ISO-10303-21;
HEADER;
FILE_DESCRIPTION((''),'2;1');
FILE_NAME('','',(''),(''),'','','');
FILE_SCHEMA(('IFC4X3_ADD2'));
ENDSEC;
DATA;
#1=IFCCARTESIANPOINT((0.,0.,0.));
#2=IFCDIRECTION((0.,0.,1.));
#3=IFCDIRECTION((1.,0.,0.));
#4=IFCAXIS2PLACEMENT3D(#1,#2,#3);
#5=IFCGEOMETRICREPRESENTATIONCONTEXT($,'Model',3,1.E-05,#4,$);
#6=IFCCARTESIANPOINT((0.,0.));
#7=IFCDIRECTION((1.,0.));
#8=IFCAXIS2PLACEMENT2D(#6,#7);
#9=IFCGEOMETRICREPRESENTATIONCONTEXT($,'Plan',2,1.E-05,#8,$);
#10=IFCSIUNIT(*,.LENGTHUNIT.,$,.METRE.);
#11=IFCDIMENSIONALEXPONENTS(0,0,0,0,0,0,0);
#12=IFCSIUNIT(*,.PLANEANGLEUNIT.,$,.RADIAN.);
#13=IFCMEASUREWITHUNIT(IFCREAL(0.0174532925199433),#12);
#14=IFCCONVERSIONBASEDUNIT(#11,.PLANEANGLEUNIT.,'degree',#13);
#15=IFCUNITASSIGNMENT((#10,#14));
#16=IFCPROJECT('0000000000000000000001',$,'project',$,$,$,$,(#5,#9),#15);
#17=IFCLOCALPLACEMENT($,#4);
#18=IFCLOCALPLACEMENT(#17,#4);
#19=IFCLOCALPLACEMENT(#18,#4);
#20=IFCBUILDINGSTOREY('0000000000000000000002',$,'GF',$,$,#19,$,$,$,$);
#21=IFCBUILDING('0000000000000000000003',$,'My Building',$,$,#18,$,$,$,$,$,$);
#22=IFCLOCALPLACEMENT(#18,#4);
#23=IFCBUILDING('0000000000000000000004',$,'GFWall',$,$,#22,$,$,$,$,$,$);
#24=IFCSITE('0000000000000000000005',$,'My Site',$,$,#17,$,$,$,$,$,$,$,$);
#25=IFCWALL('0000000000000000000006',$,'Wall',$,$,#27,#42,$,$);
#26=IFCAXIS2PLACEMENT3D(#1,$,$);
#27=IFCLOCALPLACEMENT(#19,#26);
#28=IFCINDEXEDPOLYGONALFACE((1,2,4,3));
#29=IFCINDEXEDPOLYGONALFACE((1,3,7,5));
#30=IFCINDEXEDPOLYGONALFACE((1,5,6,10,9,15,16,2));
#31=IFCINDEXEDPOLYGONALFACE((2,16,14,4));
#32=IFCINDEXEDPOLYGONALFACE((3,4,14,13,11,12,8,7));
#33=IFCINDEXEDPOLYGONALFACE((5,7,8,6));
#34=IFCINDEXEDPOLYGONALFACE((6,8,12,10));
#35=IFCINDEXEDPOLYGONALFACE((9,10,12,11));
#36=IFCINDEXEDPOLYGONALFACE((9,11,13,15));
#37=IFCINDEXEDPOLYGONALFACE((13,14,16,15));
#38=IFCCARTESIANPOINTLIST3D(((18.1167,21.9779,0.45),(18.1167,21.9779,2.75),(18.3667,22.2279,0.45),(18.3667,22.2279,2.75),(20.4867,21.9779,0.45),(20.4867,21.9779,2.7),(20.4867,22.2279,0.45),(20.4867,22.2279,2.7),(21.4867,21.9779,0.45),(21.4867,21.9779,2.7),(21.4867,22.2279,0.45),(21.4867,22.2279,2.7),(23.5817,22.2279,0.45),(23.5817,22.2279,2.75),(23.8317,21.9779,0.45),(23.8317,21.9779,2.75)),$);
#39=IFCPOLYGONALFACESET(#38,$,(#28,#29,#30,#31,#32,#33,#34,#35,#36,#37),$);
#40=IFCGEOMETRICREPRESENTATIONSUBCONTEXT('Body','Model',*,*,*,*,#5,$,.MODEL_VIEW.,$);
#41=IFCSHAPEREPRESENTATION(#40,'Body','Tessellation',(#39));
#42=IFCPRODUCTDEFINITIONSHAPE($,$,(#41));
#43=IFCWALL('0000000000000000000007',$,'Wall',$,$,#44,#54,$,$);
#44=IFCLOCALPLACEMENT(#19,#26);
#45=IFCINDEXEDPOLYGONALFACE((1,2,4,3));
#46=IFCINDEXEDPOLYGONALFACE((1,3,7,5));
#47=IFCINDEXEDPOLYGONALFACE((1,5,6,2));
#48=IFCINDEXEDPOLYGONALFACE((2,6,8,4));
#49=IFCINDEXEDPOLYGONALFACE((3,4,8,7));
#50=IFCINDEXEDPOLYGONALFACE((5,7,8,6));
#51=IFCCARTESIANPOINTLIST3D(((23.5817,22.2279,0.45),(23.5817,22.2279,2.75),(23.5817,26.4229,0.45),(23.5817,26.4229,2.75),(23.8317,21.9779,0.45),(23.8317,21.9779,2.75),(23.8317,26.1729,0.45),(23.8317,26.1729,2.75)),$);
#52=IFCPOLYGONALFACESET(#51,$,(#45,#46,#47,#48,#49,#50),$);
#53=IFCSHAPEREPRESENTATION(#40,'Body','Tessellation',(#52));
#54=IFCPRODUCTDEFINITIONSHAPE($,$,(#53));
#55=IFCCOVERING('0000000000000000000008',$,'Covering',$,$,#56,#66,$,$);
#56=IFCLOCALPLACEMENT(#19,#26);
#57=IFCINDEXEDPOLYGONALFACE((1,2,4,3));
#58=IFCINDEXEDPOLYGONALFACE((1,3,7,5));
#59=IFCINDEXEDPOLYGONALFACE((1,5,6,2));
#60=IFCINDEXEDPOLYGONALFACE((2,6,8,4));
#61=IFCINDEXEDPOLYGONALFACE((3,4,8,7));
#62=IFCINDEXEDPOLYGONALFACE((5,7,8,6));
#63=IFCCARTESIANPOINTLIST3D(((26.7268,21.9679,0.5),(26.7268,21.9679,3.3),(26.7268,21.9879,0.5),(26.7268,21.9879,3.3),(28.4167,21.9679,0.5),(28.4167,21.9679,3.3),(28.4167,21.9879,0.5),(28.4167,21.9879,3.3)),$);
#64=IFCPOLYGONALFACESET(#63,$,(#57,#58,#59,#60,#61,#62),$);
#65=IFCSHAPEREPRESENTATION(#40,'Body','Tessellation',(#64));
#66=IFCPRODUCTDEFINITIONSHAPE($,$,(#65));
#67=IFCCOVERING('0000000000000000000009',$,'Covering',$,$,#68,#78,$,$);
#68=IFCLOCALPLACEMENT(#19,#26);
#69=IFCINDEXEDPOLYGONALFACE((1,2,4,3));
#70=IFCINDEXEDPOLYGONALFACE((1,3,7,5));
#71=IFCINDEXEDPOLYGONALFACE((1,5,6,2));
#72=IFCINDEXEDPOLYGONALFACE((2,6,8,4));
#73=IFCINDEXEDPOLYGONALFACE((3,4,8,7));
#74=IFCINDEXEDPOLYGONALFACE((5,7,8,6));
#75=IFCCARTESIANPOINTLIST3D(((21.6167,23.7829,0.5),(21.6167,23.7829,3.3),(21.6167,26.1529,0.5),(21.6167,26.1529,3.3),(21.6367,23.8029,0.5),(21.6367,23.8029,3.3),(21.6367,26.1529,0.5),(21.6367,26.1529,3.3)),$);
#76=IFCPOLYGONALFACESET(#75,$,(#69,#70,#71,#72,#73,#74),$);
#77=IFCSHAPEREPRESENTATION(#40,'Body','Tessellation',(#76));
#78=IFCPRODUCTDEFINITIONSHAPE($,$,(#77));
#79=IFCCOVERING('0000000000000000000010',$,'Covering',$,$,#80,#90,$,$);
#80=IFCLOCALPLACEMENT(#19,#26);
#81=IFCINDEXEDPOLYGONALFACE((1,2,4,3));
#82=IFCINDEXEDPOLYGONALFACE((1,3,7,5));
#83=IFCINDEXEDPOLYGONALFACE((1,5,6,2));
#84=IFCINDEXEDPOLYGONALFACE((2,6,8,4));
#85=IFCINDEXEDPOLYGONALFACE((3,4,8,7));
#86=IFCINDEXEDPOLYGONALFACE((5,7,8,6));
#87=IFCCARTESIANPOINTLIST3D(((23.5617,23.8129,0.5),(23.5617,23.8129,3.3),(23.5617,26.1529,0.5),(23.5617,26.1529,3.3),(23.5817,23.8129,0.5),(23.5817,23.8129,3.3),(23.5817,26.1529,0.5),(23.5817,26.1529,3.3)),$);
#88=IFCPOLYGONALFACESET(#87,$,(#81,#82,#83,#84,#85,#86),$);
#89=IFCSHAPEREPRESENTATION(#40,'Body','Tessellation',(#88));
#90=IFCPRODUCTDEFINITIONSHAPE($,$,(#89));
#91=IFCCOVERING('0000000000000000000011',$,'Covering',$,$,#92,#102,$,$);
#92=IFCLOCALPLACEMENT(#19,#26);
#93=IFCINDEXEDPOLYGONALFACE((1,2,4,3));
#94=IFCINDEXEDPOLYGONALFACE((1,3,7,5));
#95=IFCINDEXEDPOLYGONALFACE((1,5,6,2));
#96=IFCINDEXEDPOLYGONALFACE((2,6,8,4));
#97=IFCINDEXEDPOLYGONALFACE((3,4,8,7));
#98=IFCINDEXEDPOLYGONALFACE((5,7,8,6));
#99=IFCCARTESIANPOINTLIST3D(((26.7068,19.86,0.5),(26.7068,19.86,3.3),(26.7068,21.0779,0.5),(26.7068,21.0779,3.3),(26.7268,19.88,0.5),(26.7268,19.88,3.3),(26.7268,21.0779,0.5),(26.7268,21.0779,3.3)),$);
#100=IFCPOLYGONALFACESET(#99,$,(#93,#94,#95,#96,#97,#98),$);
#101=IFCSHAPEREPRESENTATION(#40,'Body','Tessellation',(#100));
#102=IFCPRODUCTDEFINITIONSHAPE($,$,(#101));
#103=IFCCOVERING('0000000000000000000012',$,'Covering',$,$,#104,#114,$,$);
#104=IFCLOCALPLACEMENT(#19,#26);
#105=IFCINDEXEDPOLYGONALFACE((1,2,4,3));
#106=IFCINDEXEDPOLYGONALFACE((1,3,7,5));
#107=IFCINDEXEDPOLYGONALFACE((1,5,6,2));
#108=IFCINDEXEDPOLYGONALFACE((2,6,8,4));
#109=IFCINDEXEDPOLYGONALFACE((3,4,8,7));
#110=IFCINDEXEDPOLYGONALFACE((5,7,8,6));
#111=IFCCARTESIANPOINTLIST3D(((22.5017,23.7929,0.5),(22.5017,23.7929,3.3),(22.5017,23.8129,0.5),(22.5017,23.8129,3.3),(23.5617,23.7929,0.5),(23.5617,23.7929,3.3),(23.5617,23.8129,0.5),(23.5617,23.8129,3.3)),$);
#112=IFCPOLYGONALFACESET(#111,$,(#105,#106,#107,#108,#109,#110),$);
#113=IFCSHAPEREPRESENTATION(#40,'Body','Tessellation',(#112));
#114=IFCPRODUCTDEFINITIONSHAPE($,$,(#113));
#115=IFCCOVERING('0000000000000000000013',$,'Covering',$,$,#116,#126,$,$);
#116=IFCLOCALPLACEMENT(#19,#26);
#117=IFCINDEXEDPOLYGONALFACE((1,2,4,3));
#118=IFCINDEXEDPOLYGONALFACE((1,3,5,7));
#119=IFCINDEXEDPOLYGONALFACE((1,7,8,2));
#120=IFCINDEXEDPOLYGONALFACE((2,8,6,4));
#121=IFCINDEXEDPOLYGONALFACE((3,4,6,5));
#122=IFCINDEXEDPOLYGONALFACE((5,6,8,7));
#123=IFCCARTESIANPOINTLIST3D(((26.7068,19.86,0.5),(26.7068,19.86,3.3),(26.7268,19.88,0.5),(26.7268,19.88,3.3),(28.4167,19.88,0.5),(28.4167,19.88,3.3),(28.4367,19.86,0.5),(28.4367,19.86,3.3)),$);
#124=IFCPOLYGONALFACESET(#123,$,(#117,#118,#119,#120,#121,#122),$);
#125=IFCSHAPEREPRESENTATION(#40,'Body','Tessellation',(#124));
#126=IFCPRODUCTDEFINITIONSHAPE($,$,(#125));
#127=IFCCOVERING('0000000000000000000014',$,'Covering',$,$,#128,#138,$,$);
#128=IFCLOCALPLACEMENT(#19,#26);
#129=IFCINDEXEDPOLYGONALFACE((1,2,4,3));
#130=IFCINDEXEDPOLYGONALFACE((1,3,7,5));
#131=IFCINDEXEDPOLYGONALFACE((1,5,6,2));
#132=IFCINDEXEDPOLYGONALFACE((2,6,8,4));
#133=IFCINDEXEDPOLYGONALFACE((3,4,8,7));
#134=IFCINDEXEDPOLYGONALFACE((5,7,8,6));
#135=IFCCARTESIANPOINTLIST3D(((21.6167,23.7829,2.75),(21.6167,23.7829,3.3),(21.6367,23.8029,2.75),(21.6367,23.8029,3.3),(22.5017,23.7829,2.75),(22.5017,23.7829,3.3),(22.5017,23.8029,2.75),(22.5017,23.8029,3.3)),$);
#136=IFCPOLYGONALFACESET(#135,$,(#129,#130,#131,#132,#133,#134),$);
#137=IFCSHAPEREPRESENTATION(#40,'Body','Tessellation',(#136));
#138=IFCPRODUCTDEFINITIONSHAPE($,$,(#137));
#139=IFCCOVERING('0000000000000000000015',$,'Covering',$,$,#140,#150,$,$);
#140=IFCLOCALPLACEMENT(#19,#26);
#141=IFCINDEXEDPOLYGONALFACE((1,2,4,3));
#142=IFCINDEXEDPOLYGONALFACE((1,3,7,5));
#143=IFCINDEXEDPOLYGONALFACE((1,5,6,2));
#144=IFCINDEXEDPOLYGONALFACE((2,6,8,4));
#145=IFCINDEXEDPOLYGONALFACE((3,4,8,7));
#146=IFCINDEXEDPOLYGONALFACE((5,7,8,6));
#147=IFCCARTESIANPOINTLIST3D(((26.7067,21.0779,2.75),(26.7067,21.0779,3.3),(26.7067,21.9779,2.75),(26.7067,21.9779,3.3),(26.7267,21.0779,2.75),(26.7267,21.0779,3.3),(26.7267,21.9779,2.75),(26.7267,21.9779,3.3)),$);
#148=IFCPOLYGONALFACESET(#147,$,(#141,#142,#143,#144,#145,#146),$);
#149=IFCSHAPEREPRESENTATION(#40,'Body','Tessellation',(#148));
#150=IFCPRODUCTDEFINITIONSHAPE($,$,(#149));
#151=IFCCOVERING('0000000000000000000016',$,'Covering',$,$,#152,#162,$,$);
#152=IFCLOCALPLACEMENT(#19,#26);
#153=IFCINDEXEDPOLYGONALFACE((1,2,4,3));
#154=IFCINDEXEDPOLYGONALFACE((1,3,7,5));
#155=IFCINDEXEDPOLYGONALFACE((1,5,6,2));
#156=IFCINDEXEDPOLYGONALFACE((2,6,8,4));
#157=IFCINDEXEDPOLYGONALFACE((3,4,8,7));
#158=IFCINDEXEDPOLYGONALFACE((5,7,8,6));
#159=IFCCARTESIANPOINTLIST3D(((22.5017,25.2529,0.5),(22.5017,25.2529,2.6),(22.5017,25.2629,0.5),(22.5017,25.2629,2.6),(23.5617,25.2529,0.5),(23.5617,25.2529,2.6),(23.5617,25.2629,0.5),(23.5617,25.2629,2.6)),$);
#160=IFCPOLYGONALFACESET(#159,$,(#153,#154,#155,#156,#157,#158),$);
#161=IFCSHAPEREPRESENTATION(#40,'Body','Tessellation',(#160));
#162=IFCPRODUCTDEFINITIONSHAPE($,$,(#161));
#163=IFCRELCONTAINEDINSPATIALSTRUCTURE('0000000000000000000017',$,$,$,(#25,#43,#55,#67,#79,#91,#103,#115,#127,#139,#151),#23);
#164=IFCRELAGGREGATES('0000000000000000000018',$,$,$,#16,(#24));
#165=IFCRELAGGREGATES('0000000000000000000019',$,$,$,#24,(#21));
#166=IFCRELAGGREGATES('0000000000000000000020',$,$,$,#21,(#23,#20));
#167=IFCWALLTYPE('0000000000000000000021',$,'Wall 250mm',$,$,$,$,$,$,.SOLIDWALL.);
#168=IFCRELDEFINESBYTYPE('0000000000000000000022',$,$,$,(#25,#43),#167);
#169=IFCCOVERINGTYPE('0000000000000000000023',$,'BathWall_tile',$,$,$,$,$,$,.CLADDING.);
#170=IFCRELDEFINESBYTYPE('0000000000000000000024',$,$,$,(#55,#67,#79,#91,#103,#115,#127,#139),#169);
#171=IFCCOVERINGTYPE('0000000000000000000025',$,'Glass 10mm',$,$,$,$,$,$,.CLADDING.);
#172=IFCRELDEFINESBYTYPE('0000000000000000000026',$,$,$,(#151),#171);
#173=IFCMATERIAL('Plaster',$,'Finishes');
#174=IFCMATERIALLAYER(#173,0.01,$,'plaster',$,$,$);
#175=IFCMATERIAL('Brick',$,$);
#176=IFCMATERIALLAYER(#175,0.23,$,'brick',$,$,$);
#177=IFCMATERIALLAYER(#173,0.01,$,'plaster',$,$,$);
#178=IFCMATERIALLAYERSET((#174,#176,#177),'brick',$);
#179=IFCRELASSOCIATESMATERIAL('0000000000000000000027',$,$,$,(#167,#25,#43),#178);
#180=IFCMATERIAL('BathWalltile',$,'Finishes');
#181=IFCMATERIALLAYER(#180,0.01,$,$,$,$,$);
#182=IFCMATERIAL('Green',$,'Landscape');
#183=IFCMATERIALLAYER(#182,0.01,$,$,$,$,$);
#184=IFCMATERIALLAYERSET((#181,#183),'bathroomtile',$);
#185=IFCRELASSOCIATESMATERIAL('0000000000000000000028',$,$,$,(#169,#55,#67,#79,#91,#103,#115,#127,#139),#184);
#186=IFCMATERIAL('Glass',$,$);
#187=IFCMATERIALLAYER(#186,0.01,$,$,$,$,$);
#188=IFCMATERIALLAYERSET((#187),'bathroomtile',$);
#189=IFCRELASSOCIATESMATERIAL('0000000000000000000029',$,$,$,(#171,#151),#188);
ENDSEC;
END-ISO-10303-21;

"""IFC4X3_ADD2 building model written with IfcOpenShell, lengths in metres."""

from ifc_helpers import new_model, entity, si_unit, converted_unit, frame, origin_with_axes, origin_2d_with_axis, place, context, subcontext, project, spatial, line, indexed_curve, outline, extrude, source, transform, mapped, material, layer, layer_set, layer_usage, type_object, element, save


model = new_model("IFC4X3_ADD2")

# Units and contexts
model_context = context("Model", 3, precision=1e-05, world=origin_with_axes())
plan_context = context("Plan", 2, precision=1e-05, world=origin_2d_with_axis())
body_context_1 = subcontext(model_context, "Body", "Model", "MODEL_VIEW")
ifc_project = project(units=[si_unit("LENGTHUNIT", "METRE"), converted_unit("PLANEANGLEUNIT", "degree", entity("IfcReal", 0.0174532925199433), si_unit("PLANEANGLEUNIT", "RADIAN"), dimensions=[0, 0, 0, 0, 0, 0, 0])], contexts=[model_context, plan_context])

# Site, buildings
site_placement = place(None, origin_with_axes())
site = spatial("IfcSite", under=ifc_project, at=site_placement, Name="My Site")
building_1_placement = place(site_placement, origin_with_axes())
building_1 = spatial("IfcBuilding", under=site, at=building_1_placement, Name="My Building")
building_2_placement = place(building_1_placement, origin_with_axes())
building_2 = spatial("IfcBuilding", under=building_1, at=building_2_placement, Name="GFWall")

# Shared definitions
ifc_material_1 = material(Name="Plaster", Category="Finishes")
ifc_material_2 = material(Name="Brick")

# Shared definitions
ifc_layer_1 = layer(ifc_material_1, 0.01, Name="plaster")
ifc_layer_2 = layer(ifc_material_2, 0.23, Name="brick")
ifc_layer_3 = layer(ifc_material_1, 0.01, Name="plaster")
ifc_layer_set_1 = layer_set([ifc_layer_1, ifc_layer_2, ifc_layer_3], Name="brick")
wall_type_1 = type_object("IfcWallType", Name="Wall 250mm", PredefinedType="SOLIDWALL", material=ifc_layer_set_1)

# Shared definitions
storey_placement = place(building_1_placement, origin_with_axes())
storey = spatial("IfcBuildingStorey", under=building_1, at=storey_placement, Name="GF")

# Wall, opening
ifc_layer_usage_1 = layer_usage(ifc_layer_set_1, "AXIS2", "POSITIVE", 0.0)
wall_1_placement = place(building_2_placement, frame((18.3667, 21.9779, 0.45), z_axis=(0.0, 0.0, 1.0), x_axis=(1.0, 0.0, 0.0)))
wall_1 = element("IfcWall", 1, at=wall_1_placement, inside=building_2, type_object=wall_type_1, material=ifc_layer_usage_1, Name="Wall", context=body_context_1, shape_type="SweptSolid", body=[
    extrude(outline(indexed_curve([(-0.25, 0.0), (0.0, 0.25), (5.215, 0.25), (5.465, 0.0)], segments=[line(1, 2, 3, 4, 1)])), origin_with_axes(), (0.0, 0.0, 1.0), 2.3),
])
shared_shape_1 = source(origin_with_axes(), body_context_1, "Body", "SweptSolid", [
    extrude(outline(indexed_curve([(0.0, 0.0), (1.0, 0.0), (1.0, 2.25), (0.0, 2.25), (0.0, 0.0)])), frame((0.0, -0.6, 0.0), z_axis=(0.0, -1.0, 0.0), x_axis=(1.0, 0.0, 0.0)), (0.0, 0.0, -1.0), 1.2),
])
opening_1_placement = place(wall_1_placement, frame((2.12, 0.0, 0.0), z_axis=(0.0, 0.0, 1.0), x_axis=(1.0, 0.0, 0.0)))
element("IfcOpeningElement", 2, at=opening_1_placement, cuts=wall_1, PredefinedType="OPENING", context=body_context_1, shape_type="MappedRepresentation", body=[
    mapped(shared_shape_1, transform((0.0, 0.0, 0.0), x_axis=(1.0, 0.0, 0.0), y_axis=(0.0, 1.0, 0.0), z_axis=(0.0, 0.0, 1.0), scale=1.0)),
])

# Wall
ifc_layer_usage_2 = layer_usage(ifc_layer_set_1, "AXIS2", "POSITIVE", 0.0)
wall_2_placement = place(building_2_placement, frame((23.8317, 21.9779, 0.45), z_axis=(0.0, 0.0, 1.0), x_axis=(0.0, 1.0, 0.0)))
element("IfcWall", 3, at=wall_2_placement, inside=building_2, type_object=wall_type_1, material=ifc_layer_usage_2, Name="Wall", context=body_context_1, shape_type="SweptSolid", body=[
    extrude(outline(indexed_curve([(0.0, 0.0), (0.25, 0.25), (4.445, 0.25), (4.195, 0.0)], segments=[line(1, 2, 3, 4, 1)])), origin_with_axes(), (0.0, 0.0, 1.0), 2.3),
])

# Coverings
ifc_material_3 = material(Name="BathWalltile", Category="Finishes")
ifc_layer_4 = layer(ifc_material_3, 0.01)
ifc_material_4 = material(Name="Green", Category="Landscape")
ifc_layer_5 = layer(ifc_material_4, 0.01)
ifc_layer_set_2 = layer_set([ifc_layer_4, ifc_layer_5], Name="bathroomtile")
ifc_layer_usage_3 = layer_usage(ifc_layer_set_2, "AXIS2", "POSITIVE", 0.0)
covering_type_1 = type_object("IfcCoveringType", Name="BathWall_tile", PredefinedType="CLADDING", material=ifc_layer_set_2)
covering_1_placement = place(building_2_placement, frame((26.7268, 21.9679, 0.5), z_axis=(0.0, 0.0, 1.0), x_axis=(1.0, 0.0, 0.0)))
element("IfcCovering", 4, at=covering_1_placement, inside=building_2, type_object=covering_type_1, material=ifc_layer_usage_3, Name="Covering", context=body_context_1, shape_type="SweptSolid", body=[
    extrude(outline(indexed_curve([(0.0, 0.0), (0.0, 0.02), (1.6899, 0.02), (1.6899, 0.0)], segments=[line(1, 2, 3, 4, 1)])), origin_with_axes(), (0.0, 0.0, 1.0), 2.8),
])
ifc_layer_usage_4 = layer_usage(ifc_layer_set_2, "AXIS2", "NEGATIVE", 0.0)
covering_2_placement = place(building_2_placement, frame((21.6367, 26.1529, 0.5), z_axis=(0.0, 0.0, 1.0), x_axis=(0.0, -1.0, 0.0)))
element("IfcCovering", 5, at=covering_2_placement, inside=building_2, type_object=covering_type_1, material=ifc_layer_usage_4, Name="Covering", context=body_context_1, shape_type="SweptSolid", body=[
    extrude(outline(indexed_curve([(0.0, -0.02), (0.0, 0.0), (2.35, 0.0), (2.37, -0.02)], segments=[line(1, 2, 3, 4, 1)])), origin_with_axes(), (0.0, 0.0, 1.0), 2.8),
])
ifc_layer_usage_5 = layer_usage(ifc_layer_set_2, "AXIS2", "NEGATIVE", 0.0)
covering_3_placement = place(building_2_placement, frame((23.5617, 23.8129, 0.5), z_axis=(0.0, 0.0, 1.0), x_axis=(0.0, 1.0, 0.0)))
element("IfcCovering", 6, at=covering_3_placement, inside=building_2, type_object=covering_type_1, material=ifc_layer_usage_5, Name="Covering", context=body_context_1, shape_type="SweptSolid", body=[
    extrude(outline(indexed_curve([(0.0, -0.02), (0.0, 0.0), (2.34, 0.0), (2.34, -0.02)], segments=[line(1, 2, 3, 4, 1)])), origin_with_axes(), (0.0, 0.0, 1.0), 2.8),
])
ifc_layer_usage_6 = layer_usage(ifc_layer_set_2, "AXIS2", "POSITIVE", 0.0)
covering_4_placement = place(building_2_placement, frame((26.7268, 19.88, 0.5), z_axis=(0.0, 0.0, 1.0), x_axis=(0.0, 1.0, 0.0)))
element("IfcCovering", 7, at=covering_4_placement, inside=building_2, type_object=covering_type_1, material=ifc_layer_usage_6, Name="Covering", context=body_context_1, shape_type="SweptSolid", body=[
    extrude(outline(indexed_curve([(0.0, 0.0), (-0.02, 0.02), (1.1979, 0.02), (1.1979, 0.0)], segments=[line(1, 2, 3, 4, 1)])), origin_with_axes(), (0.0, 0.0, 1.0), 2.8),
])
ifc_layer_usage_7 = layer_usage(ifc_layer_set_2, "AXIS2", "NEGATIVE", 0.0)
covering_5_placement = place(building_2_placement, frame((22.5017, 23.8129, 0.5), z_axis=(0.0, 0.0, 1.0), x_axis=(1.0, 0.0, 0.0)))
element("IfcCovering", 8, at=covering_5_placement, inside=building_2, type_object=covering_type_1, material=ifc_layer_usage_7, Name="Covering", context=body_context_1, shape_type="SweptSolid", body=[
    extrude(outline(indexed_curve([(0.0, -0.02), (0.0, 0.0), (1.06, 0.0), (1.06, -0.02)], segments=[line(1, 2, 3, 4, 1)])), origin_with_axes(), (0.0, 0.0, 1.0), 2.8),
])
ifc_layer_usage_8 = layer_usage(ifc_layer_set_2, "AXIS2", "NEGATIVE", 0.0)
covering_6_placement = place(building_2_placement, frame((26.7268, 19.88, 0.5), z_axis=(0.0, 0.0, 1.0), x_axis=(1.0, 0.0, 0.0)))
element("IfcCovering", 9, at=covering_6_placement, inside=building_2, type_object=covering_type_1, material=ifc_layer_usage_8, Name="Covering", context=body_context_1, shape_type="SweptSolid", body=[
    extrude(outline(indexed_curve([(-0.02, -0.02), (0.0, 0.0), (1.6899, 0.0), (1.7099, -0.02)], segments=[line(1, 2, 3, 4, 1)])), origin_with_axes(), (0.0, 0.0, 1.0), 2.8),
])
ifc_layer_usage_9 = layer_usage(ifc_layer_set_2, "AXIS2", "NEGATIVE", 0.0)
covering_7_placement = place(building_2_placement, frame((21.6367, 23.8029, 2.75), z_axis=(0.0, 0.0, 1.0), x_axis=(1.0, 0.0, 0.0)))
element("IfcCovering", 10, at=covering_7_placement, inside=building_2, type_object=covering_type_1, material=ifc_layer_usage_9, Name="Covering", context=body_context_1, shape_type="SweptSolid", body=[
    extrude(outline(indexed_curve([(-0.02, -0.02), (0.0, 0.0), (0.865, 0.0), (0.865, -0.02)], segments=[line(1, 2, 3, 4, 1)])), origin_with_axes(), (0.0, 0.0, 1.0), 0.55),
])
ifc_layer_usage_10 = layer_usage(ifc_layer_set_2, "AXIS2", "NEGATIVE", 0.0)
covering_8_placement = place(building_2_placement, frame((26.7267, 21.9779, 2.75), z_axis=(0.0, 0.0, 1.0), x_axis=(-0.000001, -1.0, 0.0)))
element("IfcCovering", 11, at=covering_8_placement, inside=building_2, type_object=covering_type_1, material=ifc_layer_usage_10, Name="Covering", context=body_context_1, shape_type="SweptSolid", body=[
    extrude(outline(indexed_curve([(0.0, -0.02), (0.0, 0.0), (0.9, 0.0), (0.9, -0.02)], segments=[line(1, 2, 3, 4, 1)])), origin_with_axes(), (0.0, 0.0, 1.0), 0.55),
])
ifc_material_5 = material(Name="Glass")
ifc_layer_6 = layer(ifc_material_5, 0.01)
ifc_layer_set_3 = layer_set([ifc_layer_6], Name="bathroomtile")
ifc_layer_usage_11 = layer_usage(ifc_layer_set_3, "AXIS2", "NEGATIVE", 0.0)
covering_type_2 = type_object("IfcCoveringType", Name="Glass 10mm", PredefinedType="CLADDING", material=ifc_layer_set_3)
covering_9_placement = place(building_2_placement, frame((22.5017, 25.2629, 0.5), z_axis=(0.0, 0.0, 1.0), x_axis=(1.0, 0.0, 0.0)))
element("IfcCovering", 12, at=covering_9_placement, inside=building_2, type_object=covering_type_2, material=ifc_layer_usage_11, Name="Covering", context=body_context_1, shape_type="SweptSolid", body=[
    extrude(outline(indexed_curve([(0.0, -0.01), (0.0, 0.0), (1.06, 0.0), (1.06, -0.01)], segments=[line(1, 2, 3, 4, 1)])), origin_with_axes(), (0.0, 0.0, 1.0), 2.1),
])

save(model, "model.ifc")
